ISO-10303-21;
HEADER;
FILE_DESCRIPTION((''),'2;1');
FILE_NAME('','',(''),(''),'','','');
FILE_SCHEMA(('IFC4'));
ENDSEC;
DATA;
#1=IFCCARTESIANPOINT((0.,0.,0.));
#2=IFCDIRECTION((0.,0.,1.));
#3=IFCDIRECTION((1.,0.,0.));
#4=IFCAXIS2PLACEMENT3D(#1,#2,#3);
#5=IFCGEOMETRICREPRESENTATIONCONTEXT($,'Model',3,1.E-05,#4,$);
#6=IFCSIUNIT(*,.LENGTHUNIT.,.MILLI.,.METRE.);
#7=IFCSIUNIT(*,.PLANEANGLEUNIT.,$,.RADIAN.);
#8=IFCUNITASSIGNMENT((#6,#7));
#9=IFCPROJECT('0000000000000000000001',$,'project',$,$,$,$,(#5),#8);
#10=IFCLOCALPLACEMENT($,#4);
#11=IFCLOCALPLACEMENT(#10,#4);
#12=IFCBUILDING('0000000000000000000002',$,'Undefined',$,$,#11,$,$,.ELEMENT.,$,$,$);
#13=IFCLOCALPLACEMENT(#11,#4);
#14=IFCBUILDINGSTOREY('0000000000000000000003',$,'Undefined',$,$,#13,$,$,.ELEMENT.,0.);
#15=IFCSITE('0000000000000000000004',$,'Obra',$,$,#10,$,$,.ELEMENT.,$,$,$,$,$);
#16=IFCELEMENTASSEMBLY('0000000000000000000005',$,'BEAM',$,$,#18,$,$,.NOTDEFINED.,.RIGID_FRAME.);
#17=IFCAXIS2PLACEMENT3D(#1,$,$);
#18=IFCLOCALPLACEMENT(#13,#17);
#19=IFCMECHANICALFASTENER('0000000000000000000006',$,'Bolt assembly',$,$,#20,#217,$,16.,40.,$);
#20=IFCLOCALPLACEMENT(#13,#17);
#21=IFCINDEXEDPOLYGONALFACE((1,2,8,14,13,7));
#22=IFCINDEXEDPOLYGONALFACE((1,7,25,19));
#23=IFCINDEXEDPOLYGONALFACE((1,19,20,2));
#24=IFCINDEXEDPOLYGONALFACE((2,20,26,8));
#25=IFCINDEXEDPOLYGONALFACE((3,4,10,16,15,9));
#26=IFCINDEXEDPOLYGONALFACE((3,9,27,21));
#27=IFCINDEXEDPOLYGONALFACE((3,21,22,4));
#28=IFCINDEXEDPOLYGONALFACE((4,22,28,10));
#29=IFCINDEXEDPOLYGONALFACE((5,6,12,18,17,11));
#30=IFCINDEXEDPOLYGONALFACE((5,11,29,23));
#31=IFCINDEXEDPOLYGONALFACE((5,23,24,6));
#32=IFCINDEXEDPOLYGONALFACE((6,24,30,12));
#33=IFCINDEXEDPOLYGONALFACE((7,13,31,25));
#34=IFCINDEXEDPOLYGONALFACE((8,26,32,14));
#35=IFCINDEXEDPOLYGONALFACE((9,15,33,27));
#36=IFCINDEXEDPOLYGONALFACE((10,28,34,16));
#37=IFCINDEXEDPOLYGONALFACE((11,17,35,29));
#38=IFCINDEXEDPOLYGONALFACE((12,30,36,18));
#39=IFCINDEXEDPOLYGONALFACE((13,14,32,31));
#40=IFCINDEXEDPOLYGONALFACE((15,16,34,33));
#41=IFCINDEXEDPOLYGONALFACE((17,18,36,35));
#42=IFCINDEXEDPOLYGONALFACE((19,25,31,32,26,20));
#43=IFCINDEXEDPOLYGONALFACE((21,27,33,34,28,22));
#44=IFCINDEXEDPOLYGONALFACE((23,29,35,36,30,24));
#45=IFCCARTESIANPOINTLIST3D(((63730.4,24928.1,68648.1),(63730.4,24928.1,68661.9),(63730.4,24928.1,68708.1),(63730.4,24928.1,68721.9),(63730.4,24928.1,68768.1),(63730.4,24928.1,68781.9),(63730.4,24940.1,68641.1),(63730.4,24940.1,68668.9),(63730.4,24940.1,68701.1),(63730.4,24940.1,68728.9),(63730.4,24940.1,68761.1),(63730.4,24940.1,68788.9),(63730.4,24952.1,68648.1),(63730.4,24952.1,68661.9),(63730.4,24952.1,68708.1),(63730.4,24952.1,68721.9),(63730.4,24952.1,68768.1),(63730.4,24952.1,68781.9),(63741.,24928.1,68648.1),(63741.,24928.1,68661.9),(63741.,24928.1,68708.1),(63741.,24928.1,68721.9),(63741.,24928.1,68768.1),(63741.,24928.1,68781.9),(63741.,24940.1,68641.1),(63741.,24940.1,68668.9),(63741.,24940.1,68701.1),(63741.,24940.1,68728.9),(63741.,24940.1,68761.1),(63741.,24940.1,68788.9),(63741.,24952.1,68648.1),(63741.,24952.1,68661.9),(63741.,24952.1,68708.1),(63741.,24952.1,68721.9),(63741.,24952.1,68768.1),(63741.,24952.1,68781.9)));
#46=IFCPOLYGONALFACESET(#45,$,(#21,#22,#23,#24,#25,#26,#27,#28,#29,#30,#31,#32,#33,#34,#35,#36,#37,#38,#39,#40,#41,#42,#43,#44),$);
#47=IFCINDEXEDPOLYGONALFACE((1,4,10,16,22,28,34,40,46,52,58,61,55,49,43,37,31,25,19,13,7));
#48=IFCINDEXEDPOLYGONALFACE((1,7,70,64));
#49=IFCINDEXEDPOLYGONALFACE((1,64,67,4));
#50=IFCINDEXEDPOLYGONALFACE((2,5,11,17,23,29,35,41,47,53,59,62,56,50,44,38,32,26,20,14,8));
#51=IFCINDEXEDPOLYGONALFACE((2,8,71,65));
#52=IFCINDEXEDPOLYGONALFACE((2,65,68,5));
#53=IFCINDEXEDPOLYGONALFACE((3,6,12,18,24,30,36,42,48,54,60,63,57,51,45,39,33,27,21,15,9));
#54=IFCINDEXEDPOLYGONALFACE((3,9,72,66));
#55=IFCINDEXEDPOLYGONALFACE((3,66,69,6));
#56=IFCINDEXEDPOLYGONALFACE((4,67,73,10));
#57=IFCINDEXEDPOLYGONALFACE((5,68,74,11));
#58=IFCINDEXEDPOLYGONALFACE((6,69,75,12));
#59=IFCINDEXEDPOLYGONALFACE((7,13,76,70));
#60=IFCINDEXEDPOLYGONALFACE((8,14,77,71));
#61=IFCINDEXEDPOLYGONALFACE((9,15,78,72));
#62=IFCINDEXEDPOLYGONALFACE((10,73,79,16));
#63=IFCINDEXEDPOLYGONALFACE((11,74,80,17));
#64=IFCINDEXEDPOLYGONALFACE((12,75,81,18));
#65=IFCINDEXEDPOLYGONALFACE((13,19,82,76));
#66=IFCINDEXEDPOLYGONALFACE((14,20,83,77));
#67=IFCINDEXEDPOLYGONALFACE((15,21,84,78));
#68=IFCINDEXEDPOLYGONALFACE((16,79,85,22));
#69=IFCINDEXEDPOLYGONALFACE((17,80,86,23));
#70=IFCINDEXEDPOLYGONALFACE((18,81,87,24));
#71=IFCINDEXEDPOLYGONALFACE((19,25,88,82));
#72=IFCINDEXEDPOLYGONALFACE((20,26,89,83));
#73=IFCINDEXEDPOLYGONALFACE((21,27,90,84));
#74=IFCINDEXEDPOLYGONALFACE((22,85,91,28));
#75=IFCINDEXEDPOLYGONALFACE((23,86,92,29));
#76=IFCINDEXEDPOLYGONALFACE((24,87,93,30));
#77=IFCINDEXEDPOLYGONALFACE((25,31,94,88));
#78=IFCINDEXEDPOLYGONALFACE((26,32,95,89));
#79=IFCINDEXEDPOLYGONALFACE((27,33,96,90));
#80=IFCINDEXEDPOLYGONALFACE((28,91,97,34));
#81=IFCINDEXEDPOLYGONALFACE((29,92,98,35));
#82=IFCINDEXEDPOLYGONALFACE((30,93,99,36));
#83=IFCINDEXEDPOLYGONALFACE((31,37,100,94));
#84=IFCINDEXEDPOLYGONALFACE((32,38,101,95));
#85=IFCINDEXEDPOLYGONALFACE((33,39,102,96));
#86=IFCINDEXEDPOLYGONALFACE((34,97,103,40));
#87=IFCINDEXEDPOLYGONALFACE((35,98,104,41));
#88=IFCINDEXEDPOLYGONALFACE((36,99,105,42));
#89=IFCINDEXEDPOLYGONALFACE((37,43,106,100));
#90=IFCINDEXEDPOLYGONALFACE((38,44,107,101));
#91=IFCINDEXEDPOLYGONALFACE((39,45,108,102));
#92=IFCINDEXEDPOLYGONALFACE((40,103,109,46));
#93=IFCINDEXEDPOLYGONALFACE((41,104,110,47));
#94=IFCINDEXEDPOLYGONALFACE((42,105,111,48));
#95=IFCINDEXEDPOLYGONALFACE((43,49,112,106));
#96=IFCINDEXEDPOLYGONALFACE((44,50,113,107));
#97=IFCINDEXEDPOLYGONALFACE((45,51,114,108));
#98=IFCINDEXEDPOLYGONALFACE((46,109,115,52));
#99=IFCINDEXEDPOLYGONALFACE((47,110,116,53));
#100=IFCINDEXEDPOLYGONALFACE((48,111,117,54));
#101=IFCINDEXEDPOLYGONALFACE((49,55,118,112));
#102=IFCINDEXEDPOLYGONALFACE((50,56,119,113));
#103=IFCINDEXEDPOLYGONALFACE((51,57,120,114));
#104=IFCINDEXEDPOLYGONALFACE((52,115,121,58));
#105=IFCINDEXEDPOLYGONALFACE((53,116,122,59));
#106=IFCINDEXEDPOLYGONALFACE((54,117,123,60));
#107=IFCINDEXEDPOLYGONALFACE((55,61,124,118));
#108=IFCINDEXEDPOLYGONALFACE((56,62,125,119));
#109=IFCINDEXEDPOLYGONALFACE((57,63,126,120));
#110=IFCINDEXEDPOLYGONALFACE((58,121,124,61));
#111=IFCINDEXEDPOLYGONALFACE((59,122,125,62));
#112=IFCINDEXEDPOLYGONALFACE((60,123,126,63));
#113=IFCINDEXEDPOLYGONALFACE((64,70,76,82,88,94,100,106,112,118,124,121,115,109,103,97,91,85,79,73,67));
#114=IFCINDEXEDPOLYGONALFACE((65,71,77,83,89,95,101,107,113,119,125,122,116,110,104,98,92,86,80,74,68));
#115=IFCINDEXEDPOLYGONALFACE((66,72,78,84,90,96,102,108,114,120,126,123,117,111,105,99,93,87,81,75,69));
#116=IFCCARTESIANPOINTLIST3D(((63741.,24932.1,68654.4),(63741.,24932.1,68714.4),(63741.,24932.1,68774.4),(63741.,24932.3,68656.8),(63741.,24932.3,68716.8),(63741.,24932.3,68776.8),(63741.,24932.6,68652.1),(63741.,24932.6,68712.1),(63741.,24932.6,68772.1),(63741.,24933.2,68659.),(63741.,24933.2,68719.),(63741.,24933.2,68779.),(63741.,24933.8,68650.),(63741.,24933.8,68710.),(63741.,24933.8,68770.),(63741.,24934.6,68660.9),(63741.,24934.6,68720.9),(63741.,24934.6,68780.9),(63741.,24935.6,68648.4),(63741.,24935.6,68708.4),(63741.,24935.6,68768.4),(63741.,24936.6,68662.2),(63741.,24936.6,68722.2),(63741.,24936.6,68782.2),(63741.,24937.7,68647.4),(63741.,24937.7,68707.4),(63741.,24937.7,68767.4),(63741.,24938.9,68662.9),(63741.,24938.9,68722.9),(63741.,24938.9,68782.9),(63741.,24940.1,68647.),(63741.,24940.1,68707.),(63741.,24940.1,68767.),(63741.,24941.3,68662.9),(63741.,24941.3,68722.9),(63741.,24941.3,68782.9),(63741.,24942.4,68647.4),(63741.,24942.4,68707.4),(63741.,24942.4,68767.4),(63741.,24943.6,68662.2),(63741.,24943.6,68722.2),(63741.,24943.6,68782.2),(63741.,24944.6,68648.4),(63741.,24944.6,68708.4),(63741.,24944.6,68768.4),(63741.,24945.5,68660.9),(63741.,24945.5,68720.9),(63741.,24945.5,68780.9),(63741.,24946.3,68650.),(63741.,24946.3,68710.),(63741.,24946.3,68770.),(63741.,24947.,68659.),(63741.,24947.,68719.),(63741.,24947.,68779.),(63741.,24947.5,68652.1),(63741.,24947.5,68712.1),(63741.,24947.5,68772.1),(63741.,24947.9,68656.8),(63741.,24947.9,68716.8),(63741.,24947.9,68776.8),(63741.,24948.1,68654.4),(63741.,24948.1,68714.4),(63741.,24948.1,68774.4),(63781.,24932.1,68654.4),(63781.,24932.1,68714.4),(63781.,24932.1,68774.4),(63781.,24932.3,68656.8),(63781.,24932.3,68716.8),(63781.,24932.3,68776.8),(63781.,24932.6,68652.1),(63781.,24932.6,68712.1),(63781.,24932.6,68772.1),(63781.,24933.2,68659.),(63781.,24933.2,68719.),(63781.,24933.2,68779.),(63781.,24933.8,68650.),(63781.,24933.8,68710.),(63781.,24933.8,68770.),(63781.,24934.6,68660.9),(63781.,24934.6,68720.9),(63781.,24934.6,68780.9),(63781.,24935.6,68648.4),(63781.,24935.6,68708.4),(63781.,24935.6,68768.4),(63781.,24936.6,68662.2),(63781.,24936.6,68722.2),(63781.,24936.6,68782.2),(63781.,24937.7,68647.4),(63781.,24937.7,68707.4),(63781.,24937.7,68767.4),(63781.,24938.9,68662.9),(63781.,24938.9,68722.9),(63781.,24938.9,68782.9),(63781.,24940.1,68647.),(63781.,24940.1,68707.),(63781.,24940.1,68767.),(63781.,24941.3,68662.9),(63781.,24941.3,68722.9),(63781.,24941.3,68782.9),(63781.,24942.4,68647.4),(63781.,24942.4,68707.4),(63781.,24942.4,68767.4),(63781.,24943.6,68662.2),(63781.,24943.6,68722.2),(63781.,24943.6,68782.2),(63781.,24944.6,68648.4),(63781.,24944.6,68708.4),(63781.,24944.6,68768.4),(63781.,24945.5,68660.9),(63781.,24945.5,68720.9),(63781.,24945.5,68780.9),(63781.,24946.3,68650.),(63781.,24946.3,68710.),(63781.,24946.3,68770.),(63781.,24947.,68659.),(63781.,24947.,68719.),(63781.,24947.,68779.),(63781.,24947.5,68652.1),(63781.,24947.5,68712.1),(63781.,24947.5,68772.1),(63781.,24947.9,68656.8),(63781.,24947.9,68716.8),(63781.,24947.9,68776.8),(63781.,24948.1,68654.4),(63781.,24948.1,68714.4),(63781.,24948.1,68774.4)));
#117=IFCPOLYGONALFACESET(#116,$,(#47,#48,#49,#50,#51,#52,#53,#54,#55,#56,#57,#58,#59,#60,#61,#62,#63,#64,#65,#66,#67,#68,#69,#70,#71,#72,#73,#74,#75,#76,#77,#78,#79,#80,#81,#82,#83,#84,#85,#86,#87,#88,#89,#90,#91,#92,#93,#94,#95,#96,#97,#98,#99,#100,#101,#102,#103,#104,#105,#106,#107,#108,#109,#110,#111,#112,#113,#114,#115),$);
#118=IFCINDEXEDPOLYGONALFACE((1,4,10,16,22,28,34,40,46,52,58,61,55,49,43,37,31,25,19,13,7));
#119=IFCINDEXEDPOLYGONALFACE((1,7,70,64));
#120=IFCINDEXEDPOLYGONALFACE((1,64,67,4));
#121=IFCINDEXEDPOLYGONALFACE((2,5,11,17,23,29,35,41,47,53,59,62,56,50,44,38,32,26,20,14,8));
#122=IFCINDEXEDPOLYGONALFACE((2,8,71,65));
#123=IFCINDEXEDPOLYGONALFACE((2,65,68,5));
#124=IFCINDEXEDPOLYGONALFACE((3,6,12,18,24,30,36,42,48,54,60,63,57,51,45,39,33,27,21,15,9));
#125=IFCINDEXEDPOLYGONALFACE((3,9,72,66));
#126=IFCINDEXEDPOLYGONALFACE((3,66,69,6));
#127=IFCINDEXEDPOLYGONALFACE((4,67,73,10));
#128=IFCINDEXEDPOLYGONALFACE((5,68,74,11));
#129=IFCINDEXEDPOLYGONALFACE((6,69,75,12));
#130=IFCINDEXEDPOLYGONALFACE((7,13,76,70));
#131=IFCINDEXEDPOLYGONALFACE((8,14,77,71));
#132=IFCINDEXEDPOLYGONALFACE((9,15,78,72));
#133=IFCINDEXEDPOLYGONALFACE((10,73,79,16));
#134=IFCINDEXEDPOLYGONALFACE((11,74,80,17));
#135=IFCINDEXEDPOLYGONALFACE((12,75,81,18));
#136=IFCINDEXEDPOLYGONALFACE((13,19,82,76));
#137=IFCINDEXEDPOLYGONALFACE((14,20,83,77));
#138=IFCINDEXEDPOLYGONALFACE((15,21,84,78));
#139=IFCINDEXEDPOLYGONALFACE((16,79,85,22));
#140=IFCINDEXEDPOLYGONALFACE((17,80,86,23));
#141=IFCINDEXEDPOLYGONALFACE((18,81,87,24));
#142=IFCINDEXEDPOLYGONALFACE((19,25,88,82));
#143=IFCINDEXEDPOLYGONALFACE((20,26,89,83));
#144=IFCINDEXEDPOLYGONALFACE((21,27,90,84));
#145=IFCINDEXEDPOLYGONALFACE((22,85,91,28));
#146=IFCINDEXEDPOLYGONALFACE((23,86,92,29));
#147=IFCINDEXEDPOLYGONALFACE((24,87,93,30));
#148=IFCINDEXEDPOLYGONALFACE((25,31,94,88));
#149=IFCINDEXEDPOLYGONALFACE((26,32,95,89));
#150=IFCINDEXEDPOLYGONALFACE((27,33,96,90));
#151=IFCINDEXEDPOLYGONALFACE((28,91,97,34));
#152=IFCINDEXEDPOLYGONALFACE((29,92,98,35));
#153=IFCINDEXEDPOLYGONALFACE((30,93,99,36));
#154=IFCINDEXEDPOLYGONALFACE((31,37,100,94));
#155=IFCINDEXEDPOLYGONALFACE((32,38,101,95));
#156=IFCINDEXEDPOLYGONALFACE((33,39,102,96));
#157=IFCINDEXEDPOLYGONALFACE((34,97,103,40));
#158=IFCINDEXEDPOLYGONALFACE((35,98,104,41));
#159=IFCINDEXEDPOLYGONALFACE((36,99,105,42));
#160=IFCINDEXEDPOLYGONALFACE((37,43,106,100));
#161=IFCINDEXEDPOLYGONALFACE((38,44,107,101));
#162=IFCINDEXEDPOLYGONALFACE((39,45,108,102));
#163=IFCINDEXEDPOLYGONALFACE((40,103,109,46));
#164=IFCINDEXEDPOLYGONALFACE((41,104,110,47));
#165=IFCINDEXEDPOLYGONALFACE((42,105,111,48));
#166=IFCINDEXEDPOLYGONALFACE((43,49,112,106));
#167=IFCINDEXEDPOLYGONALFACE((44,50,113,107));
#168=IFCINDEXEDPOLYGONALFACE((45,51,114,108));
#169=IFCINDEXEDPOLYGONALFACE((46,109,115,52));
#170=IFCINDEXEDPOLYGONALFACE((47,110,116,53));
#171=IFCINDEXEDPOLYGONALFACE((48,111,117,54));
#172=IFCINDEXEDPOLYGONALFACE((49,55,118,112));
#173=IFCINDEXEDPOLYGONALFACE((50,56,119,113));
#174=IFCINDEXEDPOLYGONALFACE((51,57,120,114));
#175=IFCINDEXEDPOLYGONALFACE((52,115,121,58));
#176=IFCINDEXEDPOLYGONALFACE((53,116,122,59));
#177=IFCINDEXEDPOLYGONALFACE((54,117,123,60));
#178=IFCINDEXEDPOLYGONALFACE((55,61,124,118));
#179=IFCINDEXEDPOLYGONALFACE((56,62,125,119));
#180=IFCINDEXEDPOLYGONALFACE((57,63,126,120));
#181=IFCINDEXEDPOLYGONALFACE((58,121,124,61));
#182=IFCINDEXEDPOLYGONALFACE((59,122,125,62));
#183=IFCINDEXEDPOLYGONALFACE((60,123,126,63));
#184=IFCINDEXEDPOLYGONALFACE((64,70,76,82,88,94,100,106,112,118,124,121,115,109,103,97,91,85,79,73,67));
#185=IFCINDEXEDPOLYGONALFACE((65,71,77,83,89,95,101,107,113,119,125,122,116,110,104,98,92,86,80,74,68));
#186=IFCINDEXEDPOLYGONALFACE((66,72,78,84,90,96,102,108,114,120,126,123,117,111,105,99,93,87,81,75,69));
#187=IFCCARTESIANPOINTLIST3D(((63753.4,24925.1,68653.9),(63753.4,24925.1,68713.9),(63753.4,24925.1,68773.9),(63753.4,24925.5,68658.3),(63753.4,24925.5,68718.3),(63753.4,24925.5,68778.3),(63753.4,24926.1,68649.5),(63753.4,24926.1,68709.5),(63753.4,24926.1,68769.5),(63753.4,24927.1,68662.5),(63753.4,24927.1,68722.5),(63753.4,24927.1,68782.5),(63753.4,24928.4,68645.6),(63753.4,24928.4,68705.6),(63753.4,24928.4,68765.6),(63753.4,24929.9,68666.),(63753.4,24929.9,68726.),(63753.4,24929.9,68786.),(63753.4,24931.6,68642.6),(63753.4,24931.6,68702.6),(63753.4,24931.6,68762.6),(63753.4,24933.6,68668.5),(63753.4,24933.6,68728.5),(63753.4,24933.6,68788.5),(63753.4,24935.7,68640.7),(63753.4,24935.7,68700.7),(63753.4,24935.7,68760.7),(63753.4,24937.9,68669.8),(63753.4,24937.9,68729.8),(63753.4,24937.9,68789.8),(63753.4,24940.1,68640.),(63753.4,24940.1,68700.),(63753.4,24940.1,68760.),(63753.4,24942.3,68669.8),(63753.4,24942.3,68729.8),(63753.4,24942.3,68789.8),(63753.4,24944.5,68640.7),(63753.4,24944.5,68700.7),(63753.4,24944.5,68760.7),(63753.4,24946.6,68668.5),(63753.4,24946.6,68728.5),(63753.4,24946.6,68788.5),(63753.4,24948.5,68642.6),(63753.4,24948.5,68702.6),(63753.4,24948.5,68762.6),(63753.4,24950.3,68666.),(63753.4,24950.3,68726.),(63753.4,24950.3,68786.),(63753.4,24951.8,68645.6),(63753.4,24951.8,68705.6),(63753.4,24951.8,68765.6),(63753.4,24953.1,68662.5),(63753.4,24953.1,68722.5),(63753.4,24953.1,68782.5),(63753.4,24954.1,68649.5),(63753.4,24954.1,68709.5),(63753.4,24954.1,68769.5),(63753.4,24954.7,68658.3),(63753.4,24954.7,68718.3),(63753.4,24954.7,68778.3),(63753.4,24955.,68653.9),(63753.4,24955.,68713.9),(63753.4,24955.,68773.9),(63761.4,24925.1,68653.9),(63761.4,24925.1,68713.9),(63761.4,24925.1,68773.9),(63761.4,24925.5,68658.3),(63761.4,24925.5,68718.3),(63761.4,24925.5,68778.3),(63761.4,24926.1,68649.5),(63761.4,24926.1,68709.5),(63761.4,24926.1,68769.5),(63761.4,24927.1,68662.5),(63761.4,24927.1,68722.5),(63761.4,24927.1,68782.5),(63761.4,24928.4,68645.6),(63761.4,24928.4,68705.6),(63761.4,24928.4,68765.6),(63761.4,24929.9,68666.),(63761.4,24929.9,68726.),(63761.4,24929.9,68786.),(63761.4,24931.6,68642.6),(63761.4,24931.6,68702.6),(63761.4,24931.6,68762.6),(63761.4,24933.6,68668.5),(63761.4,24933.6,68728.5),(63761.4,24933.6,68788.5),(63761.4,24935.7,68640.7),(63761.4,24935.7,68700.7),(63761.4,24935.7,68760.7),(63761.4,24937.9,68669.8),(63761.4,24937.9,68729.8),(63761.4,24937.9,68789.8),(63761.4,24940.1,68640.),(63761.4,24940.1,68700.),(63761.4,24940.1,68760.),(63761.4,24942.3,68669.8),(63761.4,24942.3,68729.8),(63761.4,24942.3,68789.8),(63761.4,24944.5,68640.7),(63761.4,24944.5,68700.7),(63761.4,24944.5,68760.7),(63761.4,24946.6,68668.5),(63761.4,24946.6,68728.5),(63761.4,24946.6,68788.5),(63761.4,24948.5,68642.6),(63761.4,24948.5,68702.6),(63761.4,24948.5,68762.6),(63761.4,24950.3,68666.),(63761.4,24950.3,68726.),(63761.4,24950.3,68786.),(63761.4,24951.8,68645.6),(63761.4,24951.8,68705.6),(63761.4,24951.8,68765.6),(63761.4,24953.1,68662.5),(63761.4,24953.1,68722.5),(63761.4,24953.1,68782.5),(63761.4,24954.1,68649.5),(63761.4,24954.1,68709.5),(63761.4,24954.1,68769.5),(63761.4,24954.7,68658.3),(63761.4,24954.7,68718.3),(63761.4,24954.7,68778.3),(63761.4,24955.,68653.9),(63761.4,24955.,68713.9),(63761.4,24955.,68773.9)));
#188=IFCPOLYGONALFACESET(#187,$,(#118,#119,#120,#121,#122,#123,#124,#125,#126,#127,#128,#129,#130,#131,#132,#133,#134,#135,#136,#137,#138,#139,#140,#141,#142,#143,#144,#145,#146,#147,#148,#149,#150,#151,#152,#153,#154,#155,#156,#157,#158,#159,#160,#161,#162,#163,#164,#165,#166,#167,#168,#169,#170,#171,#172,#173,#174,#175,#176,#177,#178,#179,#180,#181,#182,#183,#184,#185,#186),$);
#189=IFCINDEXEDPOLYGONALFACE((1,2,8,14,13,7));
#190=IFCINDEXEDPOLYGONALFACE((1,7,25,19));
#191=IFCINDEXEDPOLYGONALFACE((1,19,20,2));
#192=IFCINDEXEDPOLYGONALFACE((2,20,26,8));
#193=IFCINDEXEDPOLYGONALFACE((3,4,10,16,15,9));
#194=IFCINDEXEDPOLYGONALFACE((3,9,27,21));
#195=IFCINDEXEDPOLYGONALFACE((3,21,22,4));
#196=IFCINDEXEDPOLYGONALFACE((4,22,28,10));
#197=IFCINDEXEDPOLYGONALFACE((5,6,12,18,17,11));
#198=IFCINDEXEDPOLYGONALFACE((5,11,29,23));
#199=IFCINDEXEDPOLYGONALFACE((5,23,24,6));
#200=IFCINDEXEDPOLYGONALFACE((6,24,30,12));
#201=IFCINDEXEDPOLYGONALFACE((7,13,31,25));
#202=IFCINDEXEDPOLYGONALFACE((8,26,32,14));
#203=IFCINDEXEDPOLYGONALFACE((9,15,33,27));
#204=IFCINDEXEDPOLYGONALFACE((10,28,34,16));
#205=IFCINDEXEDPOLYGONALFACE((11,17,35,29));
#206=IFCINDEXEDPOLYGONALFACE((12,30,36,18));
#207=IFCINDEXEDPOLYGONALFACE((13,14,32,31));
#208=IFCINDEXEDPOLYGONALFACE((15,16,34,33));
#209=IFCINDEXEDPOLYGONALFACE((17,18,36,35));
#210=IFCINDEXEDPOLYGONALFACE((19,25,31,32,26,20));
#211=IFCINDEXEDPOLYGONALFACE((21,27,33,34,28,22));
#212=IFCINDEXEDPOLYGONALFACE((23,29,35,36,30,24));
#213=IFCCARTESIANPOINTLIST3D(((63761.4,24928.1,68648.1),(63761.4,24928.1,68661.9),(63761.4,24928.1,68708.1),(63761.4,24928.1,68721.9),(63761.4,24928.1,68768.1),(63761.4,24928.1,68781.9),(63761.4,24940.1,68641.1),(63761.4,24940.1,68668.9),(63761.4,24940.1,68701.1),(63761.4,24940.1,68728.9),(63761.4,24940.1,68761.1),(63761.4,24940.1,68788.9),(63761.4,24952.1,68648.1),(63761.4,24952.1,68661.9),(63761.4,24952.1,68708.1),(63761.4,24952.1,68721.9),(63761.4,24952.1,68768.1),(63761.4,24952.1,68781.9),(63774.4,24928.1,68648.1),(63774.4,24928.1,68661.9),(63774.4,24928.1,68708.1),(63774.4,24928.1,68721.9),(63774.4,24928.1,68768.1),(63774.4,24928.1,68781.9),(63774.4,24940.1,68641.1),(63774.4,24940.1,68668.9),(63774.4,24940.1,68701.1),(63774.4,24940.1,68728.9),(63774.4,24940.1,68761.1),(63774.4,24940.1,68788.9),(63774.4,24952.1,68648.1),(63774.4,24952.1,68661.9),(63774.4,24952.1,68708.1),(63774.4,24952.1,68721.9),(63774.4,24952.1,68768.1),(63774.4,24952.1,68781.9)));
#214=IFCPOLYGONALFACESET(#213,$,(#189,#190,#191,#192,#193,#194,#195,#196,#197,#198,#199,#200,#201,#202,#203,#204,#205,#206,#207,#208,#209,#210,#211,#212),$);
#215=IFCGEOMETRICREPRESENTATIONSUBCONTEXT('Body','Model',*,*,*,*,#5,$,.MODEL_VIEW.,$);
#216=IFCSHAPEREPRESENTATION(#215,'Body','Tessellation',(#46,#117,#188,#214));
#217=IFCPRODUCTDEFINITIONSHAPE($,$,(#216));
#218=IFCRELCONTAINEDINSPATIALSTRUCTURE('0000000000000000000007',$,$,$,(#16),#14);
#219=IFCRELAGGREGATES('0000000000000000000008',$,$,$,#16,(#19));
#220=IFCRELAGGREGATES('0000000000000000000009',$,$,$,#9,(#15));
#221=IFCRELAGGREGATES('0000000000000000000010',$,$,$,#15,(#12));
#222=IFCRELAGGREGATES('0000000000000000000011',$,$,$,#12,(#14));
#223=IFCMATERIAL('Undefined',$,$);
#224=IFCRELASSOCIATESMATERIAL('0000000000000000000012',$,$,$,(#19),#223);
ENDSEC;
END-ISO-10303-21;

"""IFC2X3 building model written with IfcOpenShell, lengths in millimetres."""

from ifc_helpers import new_model, si_unit, frame, origin_with_axes, origin_2d_with_axis, place, context, subcontext, project, spatial, polyline, circle, outline, extrude, source, transform, mapped, material, element, aggregate, save


model = new_model("IFC2X3")

# Units and contexts
model_context = context("Model", 3, precision=1e-05, world=origin_with_axes())
body_context = subcontext(model_context, "Body", "Model", "MODEL_VIEW")
ifc_project = project(units=[si_unit("LENGTHUNIT", "METRE", prefix="MILLI"), si_unit("PLANEANGLEUNIT", "RADIAN")], contexts=[model_context])

# Site, building, storey
site_placement = place(None, origin_with_axes())
site = spatial("IfcSite", under=ifc_project, at=site_placement, Name="Obra", CompositionType="ELEMENT")
building_placement = place(site_placement, origin_with_axes())
building = spatial("IfcBuilding", under=site, at=building_placement, Name="Undefined", CompositionType="ELEMENT")
storey_placement = place(building_placement, origin_with_axes())
storey = spatial("IfcBuildingStorey", under=building, at=storey_placement, Name="Undefined", CompositionType="ELEMENT", Elevation=0.0)

# Element assembly, mechanical fastener
ifc_material_1 = material(Name="Undefined")
shared_shape_1 = source(origin_with_axes(), body_context, "Body", "SweptSolid", [
    extrude(outline(polyline([(13.9, 0.0), (6.9, 12.0), (-6.9, 12.0), (-13.9, 0.0), (-6.9, -12.0), (6.9, -12.0), (13.9, 0.0)])), frame((0.0, -19.7, 0.0), z_axis=(0.0, 1.0, 0.0), x_axis=(1.0, 0.0, 0.0)), (0.0, 0.0, 1.0), 10.6),
    extrude(circle(Radius=8.0, at=origin_2d_with_axis()), frame((0.0, -9.1, 0.0), z_axis=(0.0, 1.0, 0.0), x_axis=(1.0, 0.0, 0.0)), (0.0, 0.0, 1.0), 40.0),
    extrude(circle(Radius=15.0, at=origin_2d_with_axis()), frame((0.0, 3.3, 0.0), z_axis=(0.0, 1.0, 0.0), x_axis=(1.0, 0.0, 0.0)), (0.0, 0.0, 1.0), 8.0),
    extrude(outline(polyline([(13.9, 0.0), (6.9, 12.0), (-6.9, 12.0), (-13.9, 0.0), (-6.9, -12.0), (6.9, -12.0), (13.9, 0.0)])), frame((0.0, 11.3, 0.0), z_axis=(0.0, 1.0, 0.0), x_axis=(1.0, 0.0, 0.0)), (0.0, 0.0, 1.0), 13.0),
])
assembly_1_placement = place(storey_placement, origin_with_axes())
assembly_1 = element("IfcElementAssembly", 1, at=assembly_1_placement, inside=storey, Name="BEAM", AssemblyPlace="NOTDEFINED", PredefinedType="RIGID_FRAME")
mechanical_fastener_1_placement = place(assembly_1_placement, frame((63750.1, 24990.1, 68835.0), z_axis=(0.000002, -1.0, 0.0), x_axis=(0.0, 0.0, -1.0)))
mechanical_fastener_1 = element("IfcMechanicalFastener", 2, at=mechanical_fastener_1_placement, material=ifc_material_1, Name="Bolt assembly", NominalDiameter=16.0, NominalLength=40.0, context=body_context, shape_type="MappedRepresentation", body=[
    mapped(shared_shape_1, transform((60.0, 0.0, 50.0))),
    mapped(shared_shape_1, transform((120.0, 0.0, 50.0))),
    mapped(shared_shape_1, transform((180.0, 0.0, 50.0))),
])
aggregate(assembly_1, [mechanical_fastener_1])

save(model, "model.ifc")
